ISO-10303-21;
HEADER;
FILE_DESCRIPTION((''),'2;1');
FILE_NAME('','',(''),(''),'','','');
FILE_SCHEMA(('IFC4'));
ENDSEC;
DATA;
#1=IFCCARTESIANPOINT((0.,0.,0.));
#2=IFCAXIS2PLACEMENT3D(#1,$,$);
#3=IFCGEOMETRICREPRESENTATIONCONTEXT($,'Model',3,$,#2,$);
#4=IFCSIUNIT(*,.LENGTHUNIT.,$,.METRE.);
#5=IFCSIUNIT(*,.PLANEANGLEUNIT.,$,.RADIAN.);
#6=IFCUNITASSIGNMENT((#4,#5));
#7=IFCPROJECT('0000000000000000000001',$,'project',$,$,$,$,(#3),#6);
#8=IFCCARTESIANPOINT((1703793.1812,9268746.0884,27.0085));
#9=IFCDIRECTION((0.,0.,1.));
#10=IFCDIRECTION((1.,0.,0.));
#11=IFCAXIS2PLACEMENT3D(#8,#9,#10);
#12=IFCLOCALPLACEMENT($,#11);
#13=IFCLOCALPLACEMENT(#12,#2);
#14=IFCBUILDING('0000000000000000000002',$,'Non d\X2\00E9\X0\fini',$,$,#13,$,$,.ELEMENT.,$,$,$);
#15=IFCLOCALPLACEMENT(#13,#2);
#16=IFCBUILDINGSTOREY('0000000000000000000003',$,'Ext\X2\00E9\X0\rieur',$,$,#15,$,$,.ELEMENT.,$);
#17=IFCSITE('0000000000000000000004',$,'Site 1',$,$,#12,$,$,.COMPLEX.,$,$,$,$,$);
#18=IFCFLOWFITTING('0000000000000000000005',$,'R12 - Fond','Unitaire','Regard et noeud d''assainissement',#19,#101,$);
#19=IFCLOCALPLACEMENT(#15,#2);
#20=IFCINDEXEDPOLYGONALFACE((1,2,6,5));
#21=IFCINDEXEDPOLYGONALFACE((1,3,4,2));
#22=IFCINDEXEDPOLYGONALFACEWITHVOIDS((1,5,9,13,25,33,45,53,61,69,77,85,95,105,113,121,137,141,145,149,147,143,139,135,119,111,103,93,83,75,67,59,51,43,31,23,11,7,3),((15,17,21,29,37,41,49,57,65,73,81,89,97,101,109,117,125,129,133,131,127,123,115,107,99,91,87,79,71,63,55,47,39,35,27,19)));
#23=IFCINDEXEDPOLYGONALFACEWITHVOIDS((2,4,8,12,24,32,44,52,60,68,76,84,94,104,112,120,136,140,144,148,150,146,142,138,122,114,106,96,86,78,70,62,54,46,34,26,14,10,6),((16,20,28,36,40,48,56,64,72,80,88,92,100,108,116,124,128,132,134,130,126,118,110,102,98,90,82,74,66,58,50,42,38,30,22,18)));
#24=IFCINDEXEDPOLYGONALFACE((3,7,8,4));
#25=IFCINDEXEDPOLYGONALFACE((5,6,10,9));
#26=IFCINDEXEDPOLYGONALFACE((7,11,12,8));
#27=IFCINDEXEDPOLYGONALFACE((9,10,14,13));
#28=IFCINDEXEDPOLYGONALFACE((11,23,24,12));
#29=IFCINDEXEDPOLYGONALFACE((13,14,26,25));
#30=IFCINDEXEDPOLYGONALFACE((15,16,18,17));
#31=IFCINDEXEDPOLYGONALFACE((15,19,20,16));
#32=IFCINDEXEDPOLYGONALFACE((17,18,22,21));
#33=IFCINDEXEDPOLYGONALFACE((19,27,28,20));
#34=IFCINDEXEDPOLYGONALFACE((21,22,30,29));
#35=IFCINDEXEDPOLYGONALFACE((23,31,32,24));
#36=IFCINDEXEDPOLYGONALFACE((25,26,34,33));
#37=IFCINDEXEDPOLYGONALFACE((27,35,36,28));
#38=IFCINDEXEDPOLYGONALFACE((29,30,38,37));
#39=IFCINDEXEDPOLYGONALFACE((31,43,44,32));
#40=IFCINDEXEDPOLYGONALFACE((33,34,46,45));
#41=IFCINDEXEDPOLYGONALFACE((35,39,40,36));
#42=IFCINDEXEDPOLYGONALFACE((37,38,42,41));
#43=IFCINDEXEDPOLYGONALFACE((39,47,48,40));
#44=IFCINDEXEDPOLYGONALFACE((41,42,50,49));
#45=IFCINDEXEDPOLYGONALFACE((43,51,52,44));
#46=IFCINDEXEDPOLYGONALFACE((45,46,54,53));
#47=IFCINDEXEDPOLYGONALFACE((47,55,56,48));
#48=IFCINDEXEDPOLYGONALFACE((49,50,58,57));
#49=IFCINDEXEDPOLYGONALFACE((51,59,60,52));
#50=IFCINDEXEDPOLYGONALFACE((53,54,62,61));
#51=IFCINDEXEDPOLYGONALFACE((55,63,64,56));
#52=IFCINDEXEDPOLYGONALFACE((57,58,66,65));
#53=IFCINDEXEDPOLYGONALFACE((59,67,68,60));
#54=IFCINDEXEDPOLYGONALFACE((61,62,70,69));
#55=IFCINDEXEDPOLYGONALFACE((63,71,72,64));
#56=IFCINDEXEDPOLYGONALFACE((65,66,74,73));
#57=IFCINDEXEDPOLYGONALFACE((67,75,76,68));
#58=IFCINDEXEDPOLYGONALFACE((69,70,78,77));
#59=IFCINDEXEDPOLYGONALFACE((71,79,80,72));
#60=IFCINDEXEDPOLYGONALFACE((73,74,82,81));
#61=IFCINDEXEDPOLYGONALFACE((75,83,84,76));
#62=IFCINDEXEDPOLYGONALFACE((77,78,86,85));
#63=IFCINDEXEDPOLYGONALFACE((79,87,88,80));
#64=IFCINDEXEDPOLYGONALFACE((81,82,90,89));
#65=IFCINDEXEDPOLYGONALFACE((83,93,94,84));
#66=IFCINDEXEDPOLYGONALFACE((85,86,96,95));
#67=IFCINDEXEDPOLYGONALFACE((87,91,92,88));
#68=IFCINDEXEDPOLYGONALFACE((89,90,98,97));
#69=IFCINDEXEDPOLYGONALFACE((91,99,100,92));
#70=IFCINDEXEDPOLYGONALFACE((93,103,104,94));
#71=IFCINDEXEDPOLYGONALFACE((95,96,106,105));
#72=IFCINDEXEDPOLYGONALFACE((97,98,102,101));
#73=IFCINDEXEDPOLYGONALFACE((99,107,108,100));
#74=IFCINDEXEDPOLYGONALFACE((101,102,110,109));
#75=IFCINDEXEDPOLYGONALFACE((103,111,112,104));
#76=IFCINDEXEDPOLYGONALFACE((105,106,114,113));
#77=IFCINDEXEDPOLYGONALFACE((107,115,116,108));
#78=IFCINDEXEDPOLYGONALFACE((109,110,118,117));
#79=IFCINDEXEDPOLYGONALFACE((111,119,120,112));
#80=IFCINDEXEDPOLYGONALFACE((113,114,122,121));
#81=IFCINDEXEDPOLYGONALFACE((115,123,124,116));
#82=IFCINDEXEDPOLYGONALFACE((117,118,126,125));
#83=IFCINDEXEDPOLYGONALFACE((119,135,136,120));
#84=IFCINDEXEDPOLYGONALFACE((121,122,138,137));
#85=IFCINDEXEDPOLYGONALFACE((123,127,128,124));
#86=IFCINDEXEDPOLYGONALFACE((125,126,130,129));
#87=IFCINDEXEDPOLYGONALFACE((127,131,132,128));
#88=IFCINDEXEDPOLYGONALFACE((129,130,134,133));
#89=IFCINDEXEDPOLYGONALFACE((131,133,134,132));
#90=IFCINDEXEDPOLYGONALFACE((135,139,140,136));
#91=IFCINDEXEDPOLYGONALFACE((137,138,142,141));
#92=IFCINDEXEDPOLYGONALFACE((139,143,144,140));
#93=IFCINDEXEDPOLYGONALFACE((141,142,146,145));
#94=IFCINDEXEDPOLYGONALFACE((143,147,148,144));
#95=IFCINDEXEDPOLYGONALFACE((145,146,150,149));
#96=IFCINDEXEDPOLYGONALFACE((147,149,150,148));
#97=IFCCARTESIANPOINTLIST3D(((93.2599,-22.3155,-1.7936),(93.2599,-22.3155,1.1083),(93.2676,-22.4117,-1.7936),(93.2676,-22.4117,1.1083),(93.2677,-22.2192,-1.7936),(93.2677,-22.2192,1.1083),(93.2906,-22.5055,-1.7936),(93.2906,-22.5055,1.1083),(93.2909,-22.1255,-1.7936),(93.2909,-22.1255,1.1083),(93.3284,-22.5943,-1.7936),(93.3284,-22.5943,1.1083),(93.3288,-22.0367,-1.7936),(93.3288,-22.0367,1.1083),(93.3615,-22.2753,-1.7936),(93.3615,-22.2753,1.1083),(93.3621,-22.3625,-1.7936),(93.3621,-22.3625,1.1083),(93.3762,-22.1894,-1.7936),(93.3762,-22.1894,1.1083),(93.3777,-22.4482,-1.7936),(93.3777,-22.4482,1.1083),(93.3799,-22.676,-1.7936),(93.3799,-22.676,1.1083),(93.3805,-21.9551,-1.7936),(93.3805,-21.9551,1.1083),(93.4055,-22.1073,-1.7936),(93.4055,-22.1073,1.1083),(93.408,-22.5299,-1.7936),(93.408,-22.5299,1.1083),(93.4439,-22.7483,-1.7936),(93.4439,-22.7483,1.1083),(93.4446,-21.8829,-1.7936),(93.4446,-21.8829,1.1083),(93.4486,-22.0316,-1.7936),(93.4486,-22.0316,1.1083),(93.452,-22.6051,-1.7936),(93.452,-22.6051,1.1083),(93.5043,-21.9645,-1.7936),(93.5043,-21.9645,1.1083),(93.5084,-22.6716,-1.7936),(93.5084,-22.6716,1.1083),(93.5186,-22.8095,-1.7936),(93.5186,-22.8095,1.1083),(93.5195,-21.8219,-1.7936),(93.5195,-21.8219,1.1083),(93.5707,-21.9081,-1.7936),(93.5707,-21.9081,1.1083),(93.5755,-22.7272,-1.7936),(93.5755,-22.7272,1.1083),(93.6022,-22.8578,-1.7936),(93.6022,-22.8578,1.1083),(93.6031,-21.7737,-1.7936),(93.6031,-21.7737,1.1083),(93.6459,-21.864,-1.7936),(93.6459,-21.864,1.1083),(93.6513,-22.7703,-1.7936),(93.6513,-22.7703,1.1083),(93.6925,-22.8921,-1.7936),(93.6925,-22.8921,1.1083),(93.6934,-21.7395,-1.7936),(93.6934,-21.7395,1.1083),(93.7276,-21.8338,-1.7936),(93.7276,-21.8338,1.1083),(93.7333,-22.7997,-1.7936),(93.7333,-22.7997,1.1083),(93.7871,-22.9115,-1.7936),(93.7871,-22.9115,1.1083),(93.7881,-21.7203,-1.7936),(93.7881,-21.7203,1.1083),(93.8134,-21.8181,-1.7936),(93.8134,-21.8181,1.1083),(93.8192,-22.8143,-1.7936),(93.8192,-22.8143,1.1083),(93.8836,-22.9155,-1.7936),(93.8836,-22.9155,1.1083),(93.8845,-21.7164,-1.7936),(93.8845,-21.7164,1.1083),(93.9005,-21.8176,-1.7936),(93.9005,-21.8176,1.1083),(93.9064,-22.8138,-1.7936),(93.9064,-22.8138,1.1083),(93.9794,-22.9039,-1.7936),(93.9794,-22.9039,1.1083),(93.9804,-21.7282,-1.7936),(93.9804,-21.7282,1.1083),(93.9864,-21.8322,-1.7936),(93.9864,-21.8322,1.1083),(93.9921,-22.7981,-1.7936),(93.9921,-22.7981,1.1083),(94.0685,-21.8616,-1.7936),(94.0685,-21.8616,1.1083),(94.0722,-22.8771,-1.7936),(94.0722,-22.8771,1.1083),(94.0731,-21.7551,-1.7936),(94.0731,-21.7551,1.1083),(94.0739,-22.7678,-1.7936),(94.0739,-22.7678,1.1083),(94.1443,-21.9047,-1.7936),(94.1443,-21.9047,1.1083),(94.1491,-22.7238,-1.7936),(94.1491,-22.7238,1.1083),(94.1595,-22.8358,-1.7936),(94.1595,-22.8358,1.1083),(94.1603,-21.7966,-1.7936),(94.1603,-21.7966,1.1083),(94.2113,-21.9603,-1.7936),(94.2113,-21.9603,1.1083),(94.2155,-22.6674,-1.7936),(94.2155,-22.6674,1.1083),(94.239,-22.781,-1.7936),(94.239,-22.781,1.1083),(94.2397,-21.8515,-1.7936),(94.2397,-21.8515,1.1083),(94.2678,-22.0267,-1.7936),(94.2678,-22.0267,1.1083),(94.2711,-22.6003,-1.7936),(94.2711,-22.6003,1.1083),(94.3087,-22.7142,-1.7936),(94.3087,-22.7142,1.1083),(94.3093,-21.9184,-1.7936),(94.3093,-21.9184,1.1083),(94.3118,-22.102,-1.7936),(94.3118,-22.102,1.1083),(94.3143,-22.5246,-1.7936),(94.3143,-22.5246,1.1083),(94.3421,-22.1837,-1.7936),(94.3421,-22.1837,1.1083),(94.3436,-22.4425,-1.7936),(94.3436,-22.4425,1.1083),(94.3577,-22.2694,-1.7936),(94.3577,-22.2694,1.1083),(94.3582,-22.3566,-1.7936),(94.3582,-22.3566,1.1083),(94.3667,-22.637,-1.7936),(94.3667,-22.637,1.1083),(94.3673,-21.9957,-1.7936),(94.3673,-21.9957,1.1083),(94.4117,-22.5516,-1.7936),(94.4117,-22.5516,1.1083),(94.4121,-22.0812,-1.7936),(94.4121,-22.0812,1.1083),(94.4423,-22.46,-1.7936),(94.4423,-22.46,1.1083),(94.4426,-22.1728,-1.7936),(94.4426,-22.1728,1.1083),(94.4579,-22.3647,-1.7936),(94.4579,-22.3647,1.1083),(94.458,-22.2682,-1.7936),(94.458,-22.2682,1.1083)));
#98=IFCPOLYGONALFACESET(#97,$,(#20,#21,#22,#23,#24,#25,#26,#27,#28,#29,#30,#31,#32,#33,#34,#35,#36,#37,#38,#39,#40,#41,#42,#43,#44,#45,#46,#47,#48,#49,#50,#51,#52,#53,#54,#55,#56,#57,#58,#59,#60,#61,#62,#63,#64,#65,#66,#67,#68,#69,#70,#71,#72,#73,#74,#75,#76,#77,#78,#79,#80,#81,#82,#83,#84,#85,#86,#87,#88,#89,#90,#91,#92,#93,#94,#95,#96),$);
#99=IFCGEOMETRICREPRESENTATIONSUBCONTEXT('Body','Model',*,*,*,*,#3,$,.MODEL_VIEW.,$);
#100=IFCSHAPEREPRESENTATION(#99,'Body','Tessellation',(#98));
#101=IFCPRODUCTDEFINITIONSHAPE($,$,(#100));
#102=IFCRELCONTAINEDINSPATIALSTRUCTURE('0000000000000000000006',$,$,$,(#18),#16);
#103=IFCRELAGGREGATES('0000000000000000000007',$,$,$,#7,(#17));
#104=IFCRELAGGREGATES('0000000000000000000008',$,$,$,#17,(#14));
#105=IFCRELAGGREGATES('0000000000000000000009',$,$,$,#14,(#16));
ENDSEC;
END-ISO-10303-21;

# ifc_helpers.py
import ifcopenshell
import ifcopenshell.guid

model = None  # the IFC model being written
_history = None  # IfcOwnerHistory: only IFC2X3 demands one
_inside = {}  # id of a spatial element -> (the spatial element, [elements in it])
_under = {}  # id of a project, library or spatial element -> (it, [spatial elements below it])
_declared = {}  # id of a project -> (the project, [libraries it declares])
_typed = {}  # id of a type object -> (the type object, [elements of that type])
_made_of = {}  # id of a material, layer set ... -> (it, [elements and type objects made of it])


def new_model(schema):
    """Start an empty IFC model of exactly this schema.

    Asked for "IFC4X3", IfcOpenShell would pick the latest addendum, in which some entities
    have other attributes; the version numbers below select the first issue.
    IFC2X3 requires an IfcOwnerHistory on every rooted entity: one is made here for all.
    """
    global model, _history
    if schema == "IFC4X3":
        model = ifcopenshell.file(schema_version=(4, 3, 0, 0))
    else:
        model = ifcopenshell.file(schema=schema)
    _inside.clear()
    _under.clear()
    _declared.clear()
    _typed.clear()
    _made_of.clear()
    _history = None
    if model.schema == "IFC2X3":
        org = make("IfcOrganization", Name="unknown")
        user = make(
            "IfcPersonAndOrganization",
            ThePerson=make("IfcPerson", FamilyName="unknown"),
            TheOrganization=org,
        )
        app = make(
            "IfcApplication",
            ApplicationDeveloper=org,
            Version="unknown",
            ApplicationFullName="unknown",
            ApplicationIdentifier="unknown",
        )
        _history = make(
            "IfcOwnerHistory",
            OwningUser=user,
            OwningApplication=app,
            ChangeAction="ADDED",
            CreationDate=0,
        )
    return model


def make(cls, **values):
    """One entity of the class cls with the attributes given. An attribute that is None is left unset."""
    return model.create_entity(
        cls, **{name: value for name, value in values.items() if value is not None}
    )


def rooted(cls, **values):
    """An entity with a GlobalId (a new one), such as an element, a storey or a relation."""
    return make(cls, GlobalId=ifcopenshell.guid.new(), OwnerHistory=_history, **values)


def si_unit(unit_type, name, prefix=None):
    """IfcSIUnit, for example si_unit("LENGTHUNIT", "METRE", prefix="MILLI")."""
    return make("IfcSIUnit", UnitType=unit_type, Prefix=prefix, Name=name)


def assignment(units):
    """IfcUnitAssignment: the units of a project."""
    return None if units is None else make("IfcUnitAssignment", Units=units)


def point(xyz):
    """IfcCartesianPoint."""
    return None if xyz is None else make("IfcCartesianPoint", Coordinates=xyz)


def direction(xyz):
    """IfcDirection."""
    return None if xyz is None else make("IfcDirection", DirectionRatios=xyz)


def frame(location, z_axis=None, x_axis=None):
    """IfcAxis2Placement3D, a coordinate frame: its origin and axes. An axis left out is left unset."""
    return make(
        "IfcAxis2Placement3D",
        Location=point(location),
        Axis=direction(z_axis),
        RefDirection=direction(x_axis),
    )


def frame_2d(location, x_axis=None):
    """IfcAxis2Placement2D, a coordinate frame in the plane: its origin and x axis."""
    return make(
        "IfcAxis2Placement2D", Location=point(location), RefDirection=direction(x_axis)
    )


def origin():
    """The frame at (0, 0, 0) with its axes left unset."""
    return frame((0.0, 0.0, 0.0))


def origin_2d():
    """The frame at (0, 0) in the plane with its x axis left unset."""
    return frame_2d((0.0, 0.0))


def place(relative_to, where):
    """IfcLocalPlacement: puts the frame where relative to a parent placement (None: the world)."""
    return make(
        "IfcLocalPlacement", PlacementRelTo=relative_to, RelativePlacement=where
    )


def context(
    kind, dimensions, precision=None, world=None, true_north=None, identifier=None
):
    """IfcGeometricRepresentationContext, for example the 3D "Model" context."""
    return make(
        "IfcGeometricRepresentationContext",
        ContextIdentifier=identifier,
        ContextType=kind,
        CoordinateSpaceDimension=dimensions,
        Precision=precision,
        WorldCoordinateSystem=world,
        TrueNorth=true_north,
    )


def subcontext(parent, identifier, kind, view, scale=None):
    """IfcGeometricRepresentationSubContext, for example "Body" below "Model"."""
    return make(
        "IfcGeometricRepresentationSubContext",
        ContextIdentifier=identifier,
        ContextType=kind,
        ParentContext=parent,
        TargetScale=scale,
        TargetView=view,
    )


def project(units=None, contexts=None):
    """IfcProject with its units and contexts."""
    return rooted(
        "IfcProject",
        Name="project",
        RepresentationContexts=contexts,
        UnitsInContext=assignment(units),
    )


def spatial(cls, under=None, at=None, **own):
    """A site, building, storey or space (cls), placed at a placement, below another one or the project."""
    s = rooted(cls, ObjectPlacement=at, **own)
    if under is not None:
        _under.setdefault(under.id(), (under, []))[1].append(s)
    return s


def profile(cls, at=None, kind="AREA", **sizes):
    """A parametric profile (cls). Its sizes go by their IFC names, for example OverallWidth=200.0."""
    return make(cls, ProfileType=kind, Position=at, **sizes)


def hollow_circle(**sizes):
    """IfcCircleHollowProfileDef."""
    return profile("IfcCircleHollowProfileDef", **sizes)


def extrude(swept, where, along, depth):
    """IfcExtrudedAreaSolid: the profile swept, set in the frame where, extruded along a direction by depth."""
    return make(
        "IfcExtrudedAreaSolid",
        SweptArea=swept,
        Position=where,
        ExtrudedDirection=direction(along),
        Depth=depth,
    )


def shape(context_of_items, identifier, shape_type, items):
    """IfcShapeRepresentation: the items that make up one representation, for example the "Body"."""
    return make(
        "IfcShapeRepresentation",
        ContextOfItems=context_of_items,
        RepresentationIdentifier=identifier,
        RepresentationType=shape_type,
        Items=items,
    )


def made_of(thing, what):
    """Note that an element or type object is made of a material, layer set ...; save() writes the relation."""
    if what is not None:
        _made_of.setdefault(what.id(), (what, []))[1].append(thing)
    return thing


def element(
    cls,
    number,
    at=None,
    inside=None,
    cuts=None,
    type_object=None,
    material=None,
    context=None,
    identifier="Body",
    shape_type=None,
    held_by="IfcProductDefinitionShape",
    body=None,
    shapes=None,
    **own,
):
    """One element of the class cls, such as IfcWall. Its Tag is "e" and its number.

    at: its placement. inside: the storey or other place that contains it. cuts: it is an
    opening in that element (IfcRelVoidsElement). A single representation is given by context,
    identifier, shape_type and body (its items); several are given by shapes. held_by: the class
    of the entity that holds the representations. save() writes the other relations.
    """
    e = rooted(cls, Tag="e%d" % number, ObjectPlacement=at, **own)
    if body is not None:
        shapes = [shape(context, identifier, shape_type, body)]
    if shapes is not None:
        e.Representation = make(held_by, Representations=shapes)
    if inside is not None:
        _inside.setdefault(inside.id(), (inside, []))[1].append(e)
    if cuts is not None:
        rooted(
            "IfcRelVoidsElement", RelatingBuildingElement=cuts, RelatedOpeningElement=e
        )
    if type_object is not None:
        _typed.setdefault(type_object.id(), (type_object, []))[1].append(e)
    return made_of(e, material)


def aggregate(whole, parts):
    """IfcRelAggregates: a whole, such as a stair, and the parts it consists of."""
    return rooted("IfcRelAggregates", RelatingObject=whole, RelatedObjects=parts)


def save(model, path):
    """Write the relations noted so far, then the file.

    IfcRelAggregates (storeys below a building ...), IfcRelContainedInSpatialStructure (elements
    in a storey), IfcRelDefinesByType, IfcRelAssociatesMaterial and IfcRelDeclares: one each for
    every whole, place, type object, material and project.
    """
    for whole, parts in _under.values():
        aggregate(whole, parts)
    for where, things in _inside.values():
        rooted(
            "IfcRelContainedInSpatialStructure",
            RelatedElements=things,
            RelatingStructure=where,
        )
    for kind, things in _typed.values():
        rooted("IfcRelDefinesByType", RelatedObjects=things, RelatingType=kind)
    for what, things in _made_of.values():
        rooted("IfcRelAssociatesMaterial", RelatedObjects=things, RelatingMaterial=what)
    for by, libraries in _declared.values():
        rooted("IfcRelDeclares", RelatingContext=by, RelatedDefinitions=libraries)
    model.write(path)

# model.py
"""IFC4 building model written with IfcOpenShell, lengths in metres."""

from ifc_helpers import new_model, si_unit, frame, origin, origin_2d, place, context, subcontext, project, spatial, hollow_circle, extrude, element, save


model = new_model("IFC4")

# Units and contexts
model_context = context("Model", 3, world=origin())
body_context = subcontext(model_context, "Body", "Model", "MODEL_VIEW")
ifc_project = project(units=[si_unit("LENGTHUNIT", "METRE"), si_unit("PLANEANGLEUNIT", "RADIAN")], contexts=[model_context])

# Site, building, storey
site_placement = place(None, frame((1703793.1812, 9268746.0884, 27.0085), z_axis=(0.0, 0.0, 1.0), x_axis=(1.0, 0.0, 0.0)))
site = spatial("IfcSite", under=ifc_project, at=site_placement, Name="Site 1", CompositionType="COMPLEX")
building_placement = place(site_placement, origin())
building = spatial("IfcBuilding", under=site, at=building_placement, Name="Non défini", CompositionType="ELEMENT")
storey_placement = place(building_placement, origin())
storey = spatial("IfcBuildingStorey", under=building, at=storey_placement, Name="Extérieur", CompositionType="ELEMENT")

# Flow fitting
flow_fitting_1_placement = place(storey_placement, origin())
element("IfcFlowFitting", 1, at=flow_fitting_1_placement, inside=storey, Name="R12 - Fond", Description="Unitaire", ObjectType="Regard et noeud d'assainissement", context=body_context, shape_type="SweptSolid", body=[
    extrude(hollow_circle(Radius=0.6, WallThickness=0.1, at=origin_2d()), frame((93.8599, -22.3159, -1.7936), z_axis=(0.0, 0.0, 1.0), x_axis=(0.996691, -0.08128, 0.0)), (0.0, 0.0, 1.0), 2.9019),
])

save(model, "model.ifc")
